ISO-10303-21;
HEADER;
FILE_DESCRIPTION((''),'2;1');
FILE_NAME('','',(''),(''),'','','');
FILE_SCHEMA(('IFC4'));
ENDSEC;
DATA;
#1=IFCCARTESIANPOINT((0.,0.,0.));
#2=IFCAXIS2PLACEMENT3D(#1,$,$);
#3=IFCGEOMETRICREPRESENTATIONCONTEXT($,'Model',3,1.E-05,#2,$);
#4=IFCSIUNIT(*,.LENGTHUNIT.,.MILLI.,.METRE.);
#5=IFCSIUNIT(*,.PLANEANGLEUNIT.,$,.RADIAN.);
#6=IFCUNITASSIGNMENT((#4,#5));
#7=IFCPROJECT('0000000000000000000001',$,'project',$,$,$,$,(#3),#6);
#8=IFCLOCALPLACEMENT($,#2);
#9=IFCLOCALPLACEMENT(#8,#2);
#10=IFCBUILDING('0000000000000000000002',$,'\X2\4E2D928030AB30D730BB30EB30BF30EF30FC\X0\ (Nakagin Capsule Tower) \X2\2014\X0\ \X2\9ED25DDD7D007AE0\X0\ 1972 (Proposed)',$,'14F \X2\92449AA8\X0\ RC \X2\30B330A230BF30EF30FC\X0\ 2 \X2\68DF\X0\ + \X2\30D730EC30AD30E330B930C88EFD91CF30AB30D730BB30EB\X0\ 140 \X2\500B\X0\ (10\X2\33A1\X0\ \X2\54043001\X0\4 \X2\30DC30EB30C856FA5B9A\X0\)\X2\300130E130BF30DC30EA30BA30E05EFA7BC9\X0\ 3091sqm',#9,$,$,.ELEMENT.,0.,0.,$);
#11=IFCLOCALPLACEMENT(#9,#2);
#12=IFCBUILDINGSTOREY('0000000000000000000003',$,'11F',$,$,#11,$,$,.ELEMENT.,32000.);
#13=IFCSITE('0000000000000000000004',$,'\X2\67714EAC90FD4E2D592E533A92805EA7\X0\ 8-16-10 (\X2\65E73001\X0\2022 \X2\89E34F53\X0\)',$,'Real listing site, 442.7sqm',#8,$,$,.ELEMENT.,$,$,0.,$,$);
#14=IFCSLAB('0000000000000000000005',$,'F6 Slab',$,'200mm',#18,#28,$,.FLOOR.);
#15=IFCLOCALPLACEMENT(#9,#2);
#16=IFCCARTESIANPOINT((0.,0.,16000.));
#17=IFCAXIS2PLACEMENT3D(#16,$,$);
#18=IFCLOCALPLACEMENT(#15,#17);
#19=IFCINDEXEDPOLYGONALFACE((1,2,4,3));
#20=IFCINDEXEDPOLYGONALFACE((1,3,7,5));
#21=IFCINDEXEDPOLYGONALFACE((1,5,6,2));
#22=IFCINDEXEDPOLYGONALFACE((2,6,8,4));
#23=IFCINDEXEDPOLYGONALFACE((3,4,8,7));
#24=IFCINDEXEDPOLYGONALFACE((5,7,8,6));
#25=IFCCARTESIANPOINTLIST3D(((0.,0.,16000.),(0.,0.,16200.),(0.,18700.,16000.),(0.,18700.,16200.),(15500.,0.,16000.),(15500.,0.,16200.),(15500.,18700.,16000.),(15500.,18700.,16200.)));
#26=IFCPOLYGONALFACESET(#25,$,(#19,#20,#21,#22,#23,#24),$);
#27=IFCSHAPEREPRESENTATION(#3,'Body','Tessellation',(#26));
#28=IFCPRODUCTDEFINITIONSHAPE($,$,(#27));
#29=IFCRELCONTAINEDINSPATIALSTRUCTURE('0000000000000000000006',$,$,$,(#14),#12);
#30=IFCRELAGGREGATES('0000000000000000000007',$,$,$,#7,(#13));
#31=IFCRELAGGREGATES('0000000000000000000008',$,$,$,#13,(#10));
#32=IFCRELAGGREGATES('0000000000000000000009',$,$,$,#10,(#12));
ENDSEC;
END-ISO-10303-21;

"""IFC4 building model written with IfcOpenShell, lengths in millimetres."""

from ifc_helpers import new_model, si_unit, frame, frame_2d, origin, place, context, project, spatial, rectangle, extrude, element, save


model = new_model("IFC4")

# Units and contexts
model_context = context("Model", 3, precision=1e-05, world=origin())
ifc_project = project(units=[si_unit("LENGTHUNIT", "METRE", prefix="MILLI"), si_unit("PLANEANGLEUNIT", "RADIAN")], contexts=[model_context])

# Site, building, storey
site_placement = place(None, origin())
site = spatial("IfcSite", under=ifc_project, at=site_placement, Name="東京都中央区銀座 8-16-10 (旧、2022 解体)", ObjectType="Real listing site, 442.7sqm", CompositionType="ELEMENT", RefElevation=0.0)
building_placement = place(site_placement, origin())
building = spatial("IfcBuilding", under=site, at=building_placement, Name="中銀カプセルタワー (Nakagin Capsule Tower) — 黒川紀章 1972 (Proposed)", ObjectType="14F 鉄骨 RC コアタワー 2 棟 + プレキャスト軽量カプセル 140 個 (10㎡ 各、4 ボルト固定)、メタボリズム建築 3091sqm", CompositionType="ELEMENT", ElevationOfRefHeight=0.0, ElevationOfTerrain=0.0)
storey_placement = place(building_placement, origin())
storey = spatial("IfcBuildingStorey", under=building, at=storey_placement, Name="11F", CompositionType="ELEMENT", Elevation=32000.0)

# Slab
placement = place(building_placement, origin())
slab_placement = place(placement, frame((0.0, 0.0, 16000.0)))
element("IfcSlab", 1, at=slab_placement, inside=storey, Name="F6 Slab", ObjectType="200mm", PredefinedType="FLOOR", context=model_context, shape_type="SweptSolid", body=[
    extrude(rectangle(XDim=15500.0, YDim=18700.0, at=frame_2d((7750.0, 9350.0))), frame((0.0, 0.0, 16000.0)), (0.0, 0.0, 1.0), 200.0),
])

save(model, "model.ifc")
